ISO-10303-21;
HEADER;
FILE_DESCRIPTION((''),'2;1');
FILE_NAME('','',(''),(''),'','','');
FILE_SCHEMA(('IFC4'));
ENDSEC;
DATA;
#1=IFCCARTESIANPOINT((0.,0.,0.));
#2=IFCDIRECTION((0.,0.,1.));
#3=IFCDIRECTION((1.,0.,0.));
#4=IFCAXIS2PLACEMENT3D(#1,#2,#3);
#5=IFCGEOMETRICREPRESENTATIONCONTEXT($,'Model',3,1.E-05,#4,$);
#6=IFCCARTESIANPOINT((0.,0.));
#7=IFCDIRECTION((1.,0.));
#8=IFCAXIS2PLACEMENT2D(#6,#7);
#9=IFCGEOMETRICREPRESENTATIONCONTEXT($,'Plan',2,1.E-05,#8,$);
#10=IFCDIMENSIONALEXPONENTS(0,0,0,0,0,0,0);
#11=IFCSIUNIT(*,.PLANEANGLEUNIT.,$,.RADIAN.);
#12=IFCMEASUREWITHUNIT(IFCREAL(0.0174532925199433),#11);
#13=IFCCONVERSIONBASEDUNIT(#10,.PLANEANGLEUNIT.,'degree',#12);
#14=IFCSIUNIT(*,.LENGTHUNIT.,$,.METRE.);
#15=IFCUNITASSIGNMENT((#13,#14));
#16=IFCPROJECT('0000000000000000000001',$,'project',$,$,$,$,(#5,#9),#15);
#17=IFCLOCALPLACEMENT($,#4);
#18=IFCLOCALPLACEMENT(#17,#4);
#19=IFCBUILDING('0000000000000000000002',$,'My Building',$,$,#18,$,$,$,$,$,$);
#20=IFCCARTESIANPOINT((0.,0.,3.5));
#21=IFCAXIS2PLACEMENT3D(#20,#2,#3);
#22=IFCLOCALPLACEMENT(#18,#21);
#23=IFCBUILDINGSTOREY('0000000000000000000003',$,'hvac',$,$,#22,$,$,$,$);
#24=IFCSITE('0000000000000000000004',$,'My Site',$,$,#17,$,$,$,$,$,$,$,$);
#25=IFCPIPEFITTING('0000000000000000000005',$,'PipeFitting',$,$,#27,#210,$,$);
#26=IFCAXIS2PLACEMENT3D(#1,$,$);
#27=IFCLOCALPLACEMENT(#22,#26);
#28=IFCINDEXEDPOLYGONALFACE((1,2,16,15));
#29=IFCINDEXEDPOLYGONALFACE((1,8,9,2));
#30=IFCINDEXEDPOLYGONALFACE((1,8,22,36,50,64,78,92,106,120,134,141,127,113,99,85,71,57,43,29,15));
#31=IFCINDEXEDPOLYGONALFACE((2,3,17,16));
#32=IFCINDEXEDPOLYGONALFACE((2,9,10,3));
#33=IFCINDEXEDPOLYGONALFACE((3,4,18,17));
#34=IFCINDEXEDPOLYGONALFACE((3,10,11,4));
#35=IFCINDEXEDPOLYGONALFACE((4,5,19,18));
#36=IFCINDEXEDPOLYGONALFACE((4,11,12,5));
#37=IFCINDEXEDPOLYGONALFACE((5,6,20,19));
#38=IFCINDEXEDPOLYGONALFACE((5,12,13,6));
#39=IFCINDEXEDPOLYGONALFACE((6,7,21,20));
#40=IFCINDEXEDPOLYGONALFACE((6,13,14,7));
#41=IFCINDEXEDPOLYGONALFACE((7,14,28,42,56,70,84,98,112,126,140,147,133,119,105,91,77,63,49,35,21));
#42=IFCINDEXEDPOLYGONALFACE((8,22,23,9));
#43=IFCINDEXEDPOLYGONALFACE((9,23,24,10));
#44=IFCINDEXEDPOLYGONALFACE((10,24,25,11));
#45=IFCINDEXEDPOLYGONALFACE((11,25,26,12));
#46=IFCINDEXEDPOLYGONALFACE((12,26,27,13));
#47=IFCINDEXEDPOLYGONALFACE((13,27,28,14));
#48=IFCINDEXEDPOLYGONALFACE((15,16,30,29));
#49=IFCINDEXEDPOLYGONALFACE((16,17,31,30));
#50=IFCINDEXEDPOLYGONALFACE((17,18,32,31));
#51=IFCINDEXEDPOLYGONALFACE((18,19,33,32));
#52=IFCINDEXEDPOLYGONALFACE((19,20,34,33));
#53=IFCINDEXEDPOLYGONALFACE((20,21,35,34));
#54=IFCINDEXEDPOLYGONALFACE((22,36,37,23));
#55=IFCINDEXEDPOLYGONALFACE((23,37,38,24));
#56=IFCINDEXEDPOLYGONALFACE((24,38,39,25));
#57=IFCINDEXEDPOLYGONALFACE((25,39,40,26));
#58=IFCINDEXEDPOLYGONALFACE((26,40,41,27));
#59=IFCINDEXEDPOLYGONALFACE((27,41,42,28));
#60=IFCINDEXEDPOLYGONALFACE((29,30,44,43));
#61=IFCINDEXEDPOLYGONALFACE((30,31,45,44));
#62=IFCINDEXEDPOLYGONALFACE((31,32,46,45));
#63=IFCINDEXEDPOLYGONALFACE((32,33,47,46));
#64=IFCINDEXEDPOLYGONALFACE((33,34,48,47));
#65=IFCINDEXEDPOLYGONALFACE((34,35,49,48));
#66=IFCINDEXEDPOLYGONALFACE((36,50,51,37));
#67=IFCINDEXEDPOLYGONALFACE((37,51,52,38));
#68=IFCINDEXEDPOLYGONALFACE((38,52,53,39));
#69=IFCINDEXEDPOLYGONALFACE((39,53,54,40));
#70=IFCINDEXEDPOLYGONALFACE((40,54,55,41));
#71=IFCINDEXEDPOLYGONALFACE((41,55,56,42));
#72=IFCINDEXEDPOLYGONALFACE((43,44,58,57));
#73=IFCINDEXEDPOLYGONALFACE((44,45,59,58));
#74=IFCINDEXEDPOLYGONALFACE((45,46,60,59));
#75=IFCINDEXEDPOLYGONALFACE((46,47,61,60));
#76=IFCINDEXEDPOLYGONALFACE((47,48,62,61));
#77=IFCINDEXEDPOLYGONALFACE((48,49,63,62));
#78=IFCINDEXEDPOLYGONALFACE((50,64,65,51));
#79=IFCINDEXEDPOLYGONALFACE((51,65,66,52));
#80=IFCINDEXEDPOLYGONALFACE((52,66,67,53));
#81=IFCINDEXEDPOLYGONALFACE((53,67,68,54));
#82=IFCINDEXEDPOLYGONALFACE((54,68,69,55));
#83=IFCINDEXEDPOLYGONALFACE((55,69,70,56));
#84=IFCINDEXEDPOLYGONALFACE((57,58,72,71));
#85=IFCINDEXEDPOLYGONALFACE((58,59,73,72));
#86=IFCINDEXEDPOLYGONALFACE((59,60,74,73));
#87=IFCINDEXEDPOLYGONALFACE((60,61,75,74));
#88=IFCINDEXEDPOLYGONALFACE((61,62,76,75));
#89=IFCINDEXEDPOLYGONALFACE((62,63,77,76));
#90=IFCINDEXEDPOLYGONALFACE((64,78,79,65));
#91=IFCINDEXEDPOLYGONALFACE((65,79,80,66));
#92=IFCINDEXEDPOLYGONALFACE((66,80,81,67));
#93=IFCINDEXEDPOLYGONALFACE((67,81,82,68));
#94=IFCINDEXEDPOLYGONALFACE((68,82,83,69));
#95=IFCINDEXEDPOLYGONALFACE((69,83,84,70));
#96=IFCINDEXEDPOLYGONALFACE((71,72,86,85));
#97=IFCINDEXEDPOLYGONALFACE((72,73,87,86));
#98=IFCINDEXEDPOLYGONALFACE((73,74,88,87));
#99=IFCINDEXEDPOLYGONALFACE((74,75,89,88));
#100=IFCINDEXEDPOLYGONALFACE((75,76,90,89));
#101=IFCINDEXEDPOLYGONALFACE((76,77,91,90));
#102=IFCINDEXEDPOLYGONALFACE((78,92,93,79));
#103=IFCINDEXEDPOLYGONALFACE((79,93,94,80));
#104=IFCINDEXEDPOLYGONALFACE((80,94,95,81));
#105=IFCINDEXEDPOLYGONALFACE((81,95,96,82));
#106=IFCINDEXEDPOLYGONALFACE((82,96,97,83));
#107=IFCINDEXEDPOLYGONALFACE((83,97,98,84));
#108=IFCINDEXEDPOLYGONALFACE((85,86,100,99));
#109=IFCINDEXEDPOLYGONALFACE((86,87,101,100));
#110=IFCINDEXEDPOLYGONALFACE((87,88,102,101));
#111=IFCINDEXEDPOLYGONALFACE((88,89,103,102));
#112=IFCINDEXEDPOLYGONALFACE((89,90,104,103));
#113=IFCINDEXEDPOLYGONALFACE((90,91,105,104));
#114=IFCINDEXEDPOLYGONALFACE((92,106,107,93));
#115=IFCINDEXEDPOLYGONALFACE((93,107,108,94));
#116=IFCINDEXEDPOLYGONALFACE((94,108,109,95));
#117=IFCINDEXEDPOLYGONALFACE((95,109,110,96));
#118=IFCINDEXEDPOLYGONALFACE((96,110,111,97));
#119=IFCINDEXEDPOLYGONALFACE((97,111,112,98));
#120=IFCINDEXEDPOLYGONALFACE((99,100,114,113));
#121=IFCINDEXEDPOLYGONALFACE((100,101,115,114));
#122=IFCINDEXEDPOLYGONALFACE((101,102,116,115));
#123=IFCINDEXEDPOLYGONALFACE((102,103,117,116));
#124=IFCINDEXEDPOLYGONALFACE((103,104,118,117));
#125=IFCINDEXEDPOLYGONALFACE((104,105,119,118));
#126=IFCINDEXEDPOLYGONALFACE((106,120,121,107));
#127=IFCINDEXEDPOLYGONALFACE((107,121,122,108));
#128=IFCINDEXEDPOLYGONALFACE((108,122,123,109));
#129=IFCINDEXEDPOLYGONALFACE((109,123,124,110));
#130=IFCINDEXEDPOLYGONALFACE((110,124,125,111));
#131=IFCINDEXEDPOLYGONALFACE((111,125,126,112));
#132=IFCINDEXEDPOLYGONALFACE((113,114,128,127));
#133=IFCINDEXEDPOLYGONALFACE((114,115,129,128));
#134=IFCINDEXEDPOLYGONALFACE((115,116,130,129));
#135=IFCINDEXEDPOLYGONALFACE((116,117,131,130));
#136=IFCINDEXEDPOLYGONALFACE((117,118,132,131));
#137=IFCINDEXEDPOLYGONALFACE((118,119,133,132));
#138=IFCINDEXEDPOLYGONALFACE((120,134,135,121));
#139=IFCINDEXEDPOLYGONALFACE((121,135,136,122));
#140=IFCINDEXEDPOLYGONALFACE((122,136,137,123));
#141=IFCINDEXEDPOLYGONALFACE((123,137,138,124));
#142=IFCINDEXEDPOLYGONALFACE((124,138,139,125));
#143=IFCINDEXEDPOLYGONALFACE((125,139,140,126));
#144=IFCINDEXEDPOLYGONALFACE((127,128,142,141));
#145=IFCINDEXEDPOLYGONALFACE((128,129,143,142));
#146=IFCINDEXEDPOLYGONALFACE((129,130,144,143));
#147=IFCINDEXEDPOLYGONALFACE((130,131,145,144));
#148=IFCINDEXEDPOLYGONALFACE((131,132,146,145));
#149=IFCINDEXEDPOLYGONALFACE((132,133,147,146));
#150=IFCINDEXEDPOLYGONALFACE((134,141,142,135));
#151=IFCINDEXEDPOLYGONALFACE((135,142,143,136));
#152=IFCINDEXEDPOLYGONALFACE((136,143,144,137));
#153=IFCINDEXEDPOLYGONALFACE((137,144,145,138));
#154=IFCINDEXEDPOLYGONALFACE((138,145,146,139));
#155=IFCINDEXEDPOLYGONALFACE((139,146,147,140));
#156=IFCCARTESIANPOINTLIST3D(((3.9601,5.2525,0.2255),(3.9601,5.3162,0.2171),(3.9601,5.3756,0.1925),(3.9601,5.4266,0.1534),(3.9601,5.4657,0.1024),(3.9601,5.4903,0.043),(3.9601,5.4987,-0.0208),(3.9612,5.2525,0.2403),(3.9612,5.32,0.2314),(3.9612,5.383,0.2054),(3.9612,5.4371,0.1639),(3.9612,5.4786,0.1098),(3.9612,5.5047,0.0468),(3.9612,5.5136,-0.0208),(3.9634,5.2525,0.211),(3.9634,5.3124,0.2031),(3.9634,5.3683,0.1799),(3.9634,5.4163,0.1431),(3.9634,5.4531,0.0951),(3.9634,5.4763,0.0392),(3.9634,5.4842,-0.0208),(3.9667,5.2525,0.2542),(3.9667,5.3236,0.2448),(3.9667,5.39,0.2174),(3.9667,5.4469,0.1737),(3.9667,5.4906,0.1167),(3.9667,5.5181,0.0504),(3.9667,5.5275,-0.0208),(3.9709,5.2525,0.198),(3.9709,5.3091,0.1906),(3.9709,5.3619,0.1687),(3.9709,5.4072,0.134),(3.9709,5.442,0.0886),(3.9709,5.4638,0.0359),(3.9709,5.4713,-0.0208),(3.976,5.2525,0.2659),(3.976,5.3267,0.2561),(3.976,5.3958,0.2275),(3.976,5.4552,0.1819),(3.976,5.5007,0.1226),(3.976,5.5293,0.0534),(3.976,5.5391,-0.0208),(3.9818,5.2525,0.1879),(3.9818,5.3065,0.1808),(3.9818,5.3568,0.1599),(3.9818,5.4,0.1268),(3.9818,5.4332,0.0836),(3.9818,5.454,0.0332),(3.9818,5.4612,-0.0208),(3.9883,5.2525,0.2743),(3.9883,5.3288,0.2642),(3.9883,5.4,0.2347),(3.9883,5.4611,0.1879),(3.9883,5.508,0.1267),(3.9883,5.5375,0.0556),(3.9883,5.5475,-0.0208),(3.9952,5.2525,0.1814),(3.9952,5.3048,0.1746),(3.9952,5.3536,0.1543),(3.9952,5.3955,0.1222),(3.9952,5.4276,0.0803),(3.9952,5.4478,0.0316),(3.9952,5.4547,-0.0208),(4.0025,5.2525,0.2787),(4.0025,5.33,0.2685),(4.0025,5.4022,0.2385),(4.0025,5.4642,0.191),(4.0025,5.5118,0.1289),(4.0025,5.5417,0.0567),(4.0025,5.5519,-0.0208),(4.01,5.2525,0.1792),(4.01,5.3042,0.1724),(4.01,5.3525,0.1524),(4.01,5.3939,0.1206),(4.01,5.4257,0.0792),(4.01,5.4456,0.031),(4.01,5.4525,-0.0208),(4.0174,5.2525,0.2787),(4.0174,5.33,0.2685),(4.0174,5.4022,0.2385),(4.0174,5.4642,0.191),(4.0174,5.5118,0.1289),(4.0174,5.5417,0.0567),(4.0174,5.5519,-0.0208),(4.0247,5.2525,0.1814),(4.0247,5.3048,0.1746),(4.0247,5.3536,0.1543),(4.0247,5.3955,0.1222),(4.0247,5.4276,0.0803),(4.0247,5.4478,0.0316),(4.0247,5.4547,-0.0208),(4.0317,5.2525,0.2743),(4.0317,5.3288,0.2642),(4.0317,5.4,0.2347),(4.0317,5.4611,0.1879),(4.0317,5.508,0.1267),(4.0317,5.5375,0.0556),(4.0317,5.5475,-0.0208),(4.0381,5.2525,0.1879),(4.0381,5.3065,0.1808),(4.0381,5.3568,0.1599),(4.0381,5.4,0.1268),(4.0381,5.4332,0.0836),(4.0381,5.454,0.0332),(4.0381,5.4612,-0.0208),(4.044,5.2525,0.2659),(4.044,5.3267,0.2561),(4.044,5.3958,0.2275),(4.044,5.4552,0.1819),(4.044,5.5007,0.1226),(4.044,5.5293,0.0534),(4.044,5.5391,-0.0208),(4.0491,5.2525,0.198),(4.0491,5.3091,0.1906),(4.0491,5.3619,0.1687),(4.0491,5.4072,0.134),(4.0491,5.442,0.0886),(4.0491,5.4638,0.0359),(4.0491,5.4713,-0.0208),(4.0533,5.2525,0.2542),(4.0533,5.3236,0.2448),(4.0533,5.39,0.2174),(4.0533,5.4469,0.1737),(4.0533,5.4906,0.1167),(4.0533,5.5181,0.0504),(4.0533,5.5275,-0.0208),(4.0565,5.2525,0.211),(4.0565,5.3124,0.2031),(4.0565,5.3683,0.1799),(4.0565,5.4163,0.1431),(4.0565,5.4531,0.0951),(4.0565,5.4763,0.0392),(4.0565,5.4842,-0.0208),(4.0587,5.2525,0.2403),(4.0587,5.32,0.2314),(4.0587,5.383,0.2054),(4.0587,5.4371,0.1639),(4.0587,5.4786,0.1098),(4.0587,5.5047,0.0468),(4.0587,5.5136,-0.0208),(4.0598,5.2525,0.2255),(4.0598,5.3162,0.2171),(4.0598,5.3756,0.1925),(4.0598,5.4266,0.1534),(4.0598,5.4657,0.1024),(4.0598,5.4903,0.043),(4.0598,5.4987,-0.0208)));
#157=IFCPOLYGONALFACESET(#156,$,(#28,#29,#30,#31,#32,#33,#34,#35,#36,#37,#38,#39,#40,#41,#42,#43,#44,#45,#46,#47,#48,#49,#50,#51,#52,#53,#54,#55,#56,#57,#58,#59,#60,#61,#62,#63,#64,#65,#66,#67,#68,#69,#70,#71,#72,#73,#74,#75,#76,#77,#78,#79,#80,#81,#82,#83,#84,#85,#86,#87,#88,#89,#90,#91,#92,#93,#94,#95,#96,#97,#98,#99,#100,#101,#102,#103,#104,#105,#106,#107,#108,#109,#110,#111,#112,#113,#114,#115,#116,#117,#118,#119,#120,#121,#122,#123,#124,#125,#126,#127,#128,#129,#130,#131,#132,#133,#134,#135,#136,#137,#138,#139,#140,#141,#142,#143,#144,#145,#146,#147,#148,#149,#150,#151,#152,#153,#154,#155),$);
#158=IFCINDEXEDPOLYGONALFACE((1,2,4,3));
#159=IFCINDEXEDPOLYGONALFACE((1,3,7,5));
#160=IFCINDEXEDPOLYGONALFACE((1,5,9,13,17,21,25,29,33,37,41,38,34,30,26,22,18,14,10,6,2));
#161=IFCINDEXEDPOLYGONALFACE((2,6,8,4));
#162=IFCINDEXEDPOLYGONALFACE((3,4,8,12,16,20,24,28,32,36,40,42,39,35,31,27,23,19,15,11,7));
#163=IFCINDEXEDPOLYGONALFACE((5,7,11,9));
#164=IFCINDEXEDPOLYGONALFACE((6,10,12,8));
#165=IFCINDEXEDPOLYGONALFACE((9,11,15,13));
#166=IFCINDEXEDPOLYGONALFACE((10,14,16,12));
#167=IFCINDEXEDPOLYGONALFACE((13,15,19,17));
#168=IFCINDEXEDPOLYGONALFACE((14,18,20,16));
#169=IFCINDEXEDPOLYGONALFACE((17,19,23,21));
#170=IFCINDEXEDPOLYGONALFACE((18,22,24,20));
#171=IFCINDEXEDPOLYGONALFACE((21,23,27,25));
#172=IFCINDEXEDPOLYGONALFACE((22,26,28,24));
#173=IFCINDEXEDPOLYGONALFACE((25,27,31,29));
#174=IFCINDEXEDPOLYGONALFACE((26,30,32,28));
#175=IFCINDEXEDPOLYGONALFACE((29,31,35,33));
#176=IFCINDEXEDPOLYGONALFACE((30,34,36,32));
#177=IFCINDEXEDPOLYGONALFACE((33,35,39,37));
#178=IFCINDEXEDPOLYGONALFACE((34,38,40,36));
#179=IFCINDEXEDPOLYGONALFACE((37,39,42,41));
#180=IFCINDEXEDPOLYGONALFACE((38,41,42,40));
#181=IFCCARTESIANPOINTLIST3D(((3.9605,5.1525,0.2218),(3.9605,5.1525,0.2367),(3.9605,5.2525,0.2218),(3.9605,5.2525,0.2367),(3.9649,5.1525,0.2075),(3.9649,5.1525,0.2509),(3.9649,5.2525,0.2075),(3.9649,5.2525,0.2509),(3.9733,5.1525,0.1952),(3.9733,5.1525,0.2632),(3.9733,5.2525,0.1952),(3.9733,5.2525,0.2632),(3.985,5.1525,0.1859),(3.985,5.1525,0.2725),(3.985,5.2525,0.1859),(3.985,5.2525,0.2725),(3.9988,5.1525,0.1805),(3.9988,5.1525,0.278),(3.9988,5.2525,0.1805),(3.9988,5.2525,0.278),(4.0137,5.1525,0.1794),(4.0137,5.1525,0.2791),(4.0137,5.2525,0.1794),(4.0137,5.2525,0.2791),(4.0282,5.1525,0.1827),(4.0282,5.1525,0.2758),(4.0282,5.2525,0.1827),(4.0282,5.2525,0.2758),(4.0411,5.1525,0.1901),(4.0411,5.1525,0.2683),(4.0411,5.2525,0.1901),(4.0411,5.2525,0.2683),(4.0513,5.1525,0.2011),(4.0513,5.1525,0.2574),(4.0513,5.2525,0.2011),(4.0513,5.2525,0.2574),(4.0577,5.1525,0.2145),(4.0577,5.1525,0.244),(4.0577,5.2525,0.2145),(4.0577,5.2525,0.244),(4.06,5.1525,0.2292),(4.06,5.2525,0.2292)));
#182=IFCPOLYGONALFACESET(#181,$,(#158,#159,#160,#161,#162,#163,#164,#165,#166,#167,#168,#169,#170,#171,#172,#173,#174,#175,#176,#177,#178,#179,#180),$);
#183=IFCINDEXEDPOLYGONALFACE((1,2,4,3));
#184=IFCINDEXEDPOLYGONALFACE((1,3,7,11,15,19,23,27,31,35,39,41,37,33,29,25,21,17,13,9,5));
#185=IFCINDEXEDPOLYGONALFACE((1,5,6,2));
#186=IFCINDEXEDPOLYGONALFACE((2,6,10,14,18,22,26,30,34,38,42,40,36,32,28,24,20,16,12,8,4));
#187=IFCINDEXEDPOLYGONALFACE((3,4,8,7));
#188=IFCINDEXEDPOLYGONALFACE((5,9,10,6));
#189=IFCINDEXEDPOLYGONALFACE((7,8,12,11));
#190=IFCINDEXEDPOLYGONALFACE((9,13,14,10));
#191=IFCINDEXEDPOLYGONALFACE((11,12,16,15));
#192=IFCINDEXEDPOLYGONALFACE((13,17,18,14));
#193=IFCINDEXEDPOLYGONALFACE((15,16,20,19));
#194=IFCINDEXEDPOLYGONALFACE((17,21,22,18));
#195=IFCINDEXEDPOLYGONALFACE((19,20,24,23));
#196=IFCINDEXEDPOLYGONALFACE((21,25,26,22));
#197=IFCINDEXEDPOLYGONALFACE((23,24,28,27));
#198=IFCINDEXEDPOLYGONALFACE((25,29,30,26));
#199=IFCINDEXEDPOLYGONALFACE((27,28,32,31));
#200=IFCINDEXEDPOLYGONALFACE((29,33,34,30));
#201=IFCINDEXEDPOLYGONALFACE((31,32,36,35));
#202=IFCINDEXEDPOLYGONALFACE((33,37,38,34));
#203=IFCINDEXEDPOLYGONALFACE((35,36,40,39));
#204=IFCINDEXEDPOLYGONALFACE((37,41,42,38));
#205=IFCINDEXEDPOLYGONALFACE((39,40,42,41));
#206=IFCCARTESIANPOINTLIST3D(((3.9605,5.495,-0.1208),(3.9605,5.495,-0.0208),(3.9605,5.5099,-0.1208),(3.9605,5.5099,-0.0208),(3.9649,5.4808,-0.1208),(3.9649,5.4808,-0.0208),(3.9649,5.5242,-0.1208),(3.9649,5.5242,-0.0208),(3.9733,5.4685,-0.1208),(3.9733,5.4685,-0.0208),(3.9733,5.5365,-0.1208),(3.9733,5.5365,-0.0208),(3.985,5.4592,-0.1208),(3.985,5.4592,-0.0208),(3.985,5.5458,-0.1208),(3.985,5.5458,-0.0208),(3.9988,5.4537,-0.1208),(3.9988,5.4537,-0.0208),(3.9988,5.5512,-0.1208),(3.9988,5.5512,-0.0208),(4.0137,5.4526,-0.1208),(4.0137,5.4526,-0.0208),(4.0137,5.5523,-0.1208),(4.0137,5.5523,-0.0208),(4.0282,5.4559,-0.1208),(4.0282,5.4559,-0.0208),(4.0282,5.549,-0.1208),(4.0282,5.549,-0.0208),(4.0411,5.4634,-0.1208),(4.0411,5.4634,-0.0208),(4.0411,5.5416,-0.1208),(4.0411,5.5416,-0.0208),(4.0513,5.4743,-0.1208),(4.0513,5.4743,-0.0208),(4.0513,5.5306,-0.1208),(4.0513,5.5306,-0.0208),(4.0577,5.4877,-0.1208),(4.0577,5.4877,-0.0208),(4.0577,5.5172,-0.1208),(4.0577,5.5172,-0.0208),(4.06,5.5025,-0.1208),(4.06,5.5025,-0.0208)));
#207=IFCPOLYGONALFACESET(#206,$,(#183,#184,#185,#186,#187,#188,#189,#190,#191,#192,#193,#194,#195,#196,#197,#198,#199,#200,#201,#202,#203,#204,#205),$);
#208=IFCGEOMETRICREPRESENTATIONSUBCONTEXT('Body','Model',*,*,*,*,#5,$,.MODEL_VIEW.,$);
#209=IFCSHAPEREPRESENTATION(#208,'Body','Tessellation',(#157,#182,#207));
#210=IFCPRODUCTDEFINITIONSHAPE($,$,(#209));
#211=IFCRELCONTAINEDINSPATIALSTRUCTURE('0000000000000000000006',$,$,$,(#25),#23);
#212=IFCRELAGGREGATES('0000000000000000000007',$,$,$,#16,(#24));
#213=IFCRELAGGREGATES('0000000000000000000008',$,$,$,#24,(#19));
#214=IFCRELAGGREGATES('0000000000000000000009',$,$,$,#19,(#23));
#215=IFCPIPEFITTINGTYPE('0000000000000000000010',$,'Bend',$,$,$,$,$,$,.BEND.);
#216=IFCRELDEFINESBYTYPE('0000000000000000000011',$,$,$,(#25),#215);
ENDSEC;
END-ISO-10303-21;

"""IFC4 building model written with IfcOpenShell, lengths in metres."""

from ifc_helpers import new_model, entity, si_unit, converted_unit, frame, origin_with_axes, origin_2d_with_axis, place, context, subcontext, project, spatial, circle, extrude, source, transform, mapped, type_object, type_shapes, element, save


model = new_model("IFC4")

# Units and contexts
model_context = context("Model", 3, precision=1e-05, world=origin_with_axes())
plan_context = context("Plan", 2, precision=1e-05, world=origin_2d_with_axis())
body_context_1 = subcontext(model_context, "Body", "Model", "MODEL_VIEW")
ifc_project = project(units=[converted_unit("PLANEANGLEUNIT", "degree", entity("IfcReal", 0.0174532925199433), si_unit("PLANEANGLEUNIT", "RADIAN"), dimensions=[0, 0, 0, 0, 0, 0, 0]), si_unit("LENGTHUNIT", "METRE")], contexts=[model_context, plan_context])

# Site, building, storey
site_placement = place(None, origin_with_axes())
site = spatial("IfcSite", under=ifc_project, at=site_placement, Name="My Site")
building_placement = place(site_placement, origin_with_axes())
building = spatial("IfcBuilding", under=site, at=building_placement, Name="My Building")
storey_placement = place(building_placement, frame((0.0, 0.0, 3.5), z_axis=(0.0, 0.0, 1.0), x_axis=(1.0, 0.0, 0.0)))
storey = spatial("IfcBuildingStorey", under=building, at=storey_placement, Name="hvac")

# Pipe fitting
pipe_fitting_type = type_object("IfcPipeFittingType", Name="Bend", PredefinedType="BEND")
shared_shape_1 = source(origin_with_axes(), body_context_1, "Body", "SolidModel", [
    entity("IfcSweptDiskSolid", entity("IfcIndexedPolyCurve", entity("IfcCartesianPointList3D", [[0.0, 0.0, -0.1], [0.0, -0.0732, -0.2768], [0.0, -0.25, -0.35]]), [entity("IfcArcIndex", [1, 2, 3])]), 0.05),
    extrude(circle(Radius=0.05), origin_with_axes(), (0.0, 0.0, -1.0), 0.1),
    extrude(circle(Radius=0.05), frame((0.0, -0.25, -0.35), z_axis=(0.0, -1.0, -0.000032), x_axis=(1.0, 0.0, 0.0)), (0.0, 0.0, 1.0), 0.1),
])
type_shapes(pipe_fitting_type, [shared_shape_1])
for number, where, z_axis, x_axis, name in (
    (1, (4.01, 5.1525, 0.2292), (0.0, -1.0, 0.0), (1.0, 0.0, 0.0), "PipeFitting"),
):
    element("IfcPipeFitting", number, at=place(storey_placement, frame(where, z_axis=z_axis, x_axis=x_axis)), inside=storey, type_object=pipe_fitting_type, Name=name, context=body_context_1, shape_type="MappedRepresentation", body=[
        mapped(shared_shape_1, transform((0.0, 0.0, 0.0), x_axis=(1.0, 0.0, 0.0), y_axis=(0.0, 1.0, 0.0), z_axis=(0.0, 0.0, 1.0), scale=1.0)),
    ])

save(model, "model.ifc")
